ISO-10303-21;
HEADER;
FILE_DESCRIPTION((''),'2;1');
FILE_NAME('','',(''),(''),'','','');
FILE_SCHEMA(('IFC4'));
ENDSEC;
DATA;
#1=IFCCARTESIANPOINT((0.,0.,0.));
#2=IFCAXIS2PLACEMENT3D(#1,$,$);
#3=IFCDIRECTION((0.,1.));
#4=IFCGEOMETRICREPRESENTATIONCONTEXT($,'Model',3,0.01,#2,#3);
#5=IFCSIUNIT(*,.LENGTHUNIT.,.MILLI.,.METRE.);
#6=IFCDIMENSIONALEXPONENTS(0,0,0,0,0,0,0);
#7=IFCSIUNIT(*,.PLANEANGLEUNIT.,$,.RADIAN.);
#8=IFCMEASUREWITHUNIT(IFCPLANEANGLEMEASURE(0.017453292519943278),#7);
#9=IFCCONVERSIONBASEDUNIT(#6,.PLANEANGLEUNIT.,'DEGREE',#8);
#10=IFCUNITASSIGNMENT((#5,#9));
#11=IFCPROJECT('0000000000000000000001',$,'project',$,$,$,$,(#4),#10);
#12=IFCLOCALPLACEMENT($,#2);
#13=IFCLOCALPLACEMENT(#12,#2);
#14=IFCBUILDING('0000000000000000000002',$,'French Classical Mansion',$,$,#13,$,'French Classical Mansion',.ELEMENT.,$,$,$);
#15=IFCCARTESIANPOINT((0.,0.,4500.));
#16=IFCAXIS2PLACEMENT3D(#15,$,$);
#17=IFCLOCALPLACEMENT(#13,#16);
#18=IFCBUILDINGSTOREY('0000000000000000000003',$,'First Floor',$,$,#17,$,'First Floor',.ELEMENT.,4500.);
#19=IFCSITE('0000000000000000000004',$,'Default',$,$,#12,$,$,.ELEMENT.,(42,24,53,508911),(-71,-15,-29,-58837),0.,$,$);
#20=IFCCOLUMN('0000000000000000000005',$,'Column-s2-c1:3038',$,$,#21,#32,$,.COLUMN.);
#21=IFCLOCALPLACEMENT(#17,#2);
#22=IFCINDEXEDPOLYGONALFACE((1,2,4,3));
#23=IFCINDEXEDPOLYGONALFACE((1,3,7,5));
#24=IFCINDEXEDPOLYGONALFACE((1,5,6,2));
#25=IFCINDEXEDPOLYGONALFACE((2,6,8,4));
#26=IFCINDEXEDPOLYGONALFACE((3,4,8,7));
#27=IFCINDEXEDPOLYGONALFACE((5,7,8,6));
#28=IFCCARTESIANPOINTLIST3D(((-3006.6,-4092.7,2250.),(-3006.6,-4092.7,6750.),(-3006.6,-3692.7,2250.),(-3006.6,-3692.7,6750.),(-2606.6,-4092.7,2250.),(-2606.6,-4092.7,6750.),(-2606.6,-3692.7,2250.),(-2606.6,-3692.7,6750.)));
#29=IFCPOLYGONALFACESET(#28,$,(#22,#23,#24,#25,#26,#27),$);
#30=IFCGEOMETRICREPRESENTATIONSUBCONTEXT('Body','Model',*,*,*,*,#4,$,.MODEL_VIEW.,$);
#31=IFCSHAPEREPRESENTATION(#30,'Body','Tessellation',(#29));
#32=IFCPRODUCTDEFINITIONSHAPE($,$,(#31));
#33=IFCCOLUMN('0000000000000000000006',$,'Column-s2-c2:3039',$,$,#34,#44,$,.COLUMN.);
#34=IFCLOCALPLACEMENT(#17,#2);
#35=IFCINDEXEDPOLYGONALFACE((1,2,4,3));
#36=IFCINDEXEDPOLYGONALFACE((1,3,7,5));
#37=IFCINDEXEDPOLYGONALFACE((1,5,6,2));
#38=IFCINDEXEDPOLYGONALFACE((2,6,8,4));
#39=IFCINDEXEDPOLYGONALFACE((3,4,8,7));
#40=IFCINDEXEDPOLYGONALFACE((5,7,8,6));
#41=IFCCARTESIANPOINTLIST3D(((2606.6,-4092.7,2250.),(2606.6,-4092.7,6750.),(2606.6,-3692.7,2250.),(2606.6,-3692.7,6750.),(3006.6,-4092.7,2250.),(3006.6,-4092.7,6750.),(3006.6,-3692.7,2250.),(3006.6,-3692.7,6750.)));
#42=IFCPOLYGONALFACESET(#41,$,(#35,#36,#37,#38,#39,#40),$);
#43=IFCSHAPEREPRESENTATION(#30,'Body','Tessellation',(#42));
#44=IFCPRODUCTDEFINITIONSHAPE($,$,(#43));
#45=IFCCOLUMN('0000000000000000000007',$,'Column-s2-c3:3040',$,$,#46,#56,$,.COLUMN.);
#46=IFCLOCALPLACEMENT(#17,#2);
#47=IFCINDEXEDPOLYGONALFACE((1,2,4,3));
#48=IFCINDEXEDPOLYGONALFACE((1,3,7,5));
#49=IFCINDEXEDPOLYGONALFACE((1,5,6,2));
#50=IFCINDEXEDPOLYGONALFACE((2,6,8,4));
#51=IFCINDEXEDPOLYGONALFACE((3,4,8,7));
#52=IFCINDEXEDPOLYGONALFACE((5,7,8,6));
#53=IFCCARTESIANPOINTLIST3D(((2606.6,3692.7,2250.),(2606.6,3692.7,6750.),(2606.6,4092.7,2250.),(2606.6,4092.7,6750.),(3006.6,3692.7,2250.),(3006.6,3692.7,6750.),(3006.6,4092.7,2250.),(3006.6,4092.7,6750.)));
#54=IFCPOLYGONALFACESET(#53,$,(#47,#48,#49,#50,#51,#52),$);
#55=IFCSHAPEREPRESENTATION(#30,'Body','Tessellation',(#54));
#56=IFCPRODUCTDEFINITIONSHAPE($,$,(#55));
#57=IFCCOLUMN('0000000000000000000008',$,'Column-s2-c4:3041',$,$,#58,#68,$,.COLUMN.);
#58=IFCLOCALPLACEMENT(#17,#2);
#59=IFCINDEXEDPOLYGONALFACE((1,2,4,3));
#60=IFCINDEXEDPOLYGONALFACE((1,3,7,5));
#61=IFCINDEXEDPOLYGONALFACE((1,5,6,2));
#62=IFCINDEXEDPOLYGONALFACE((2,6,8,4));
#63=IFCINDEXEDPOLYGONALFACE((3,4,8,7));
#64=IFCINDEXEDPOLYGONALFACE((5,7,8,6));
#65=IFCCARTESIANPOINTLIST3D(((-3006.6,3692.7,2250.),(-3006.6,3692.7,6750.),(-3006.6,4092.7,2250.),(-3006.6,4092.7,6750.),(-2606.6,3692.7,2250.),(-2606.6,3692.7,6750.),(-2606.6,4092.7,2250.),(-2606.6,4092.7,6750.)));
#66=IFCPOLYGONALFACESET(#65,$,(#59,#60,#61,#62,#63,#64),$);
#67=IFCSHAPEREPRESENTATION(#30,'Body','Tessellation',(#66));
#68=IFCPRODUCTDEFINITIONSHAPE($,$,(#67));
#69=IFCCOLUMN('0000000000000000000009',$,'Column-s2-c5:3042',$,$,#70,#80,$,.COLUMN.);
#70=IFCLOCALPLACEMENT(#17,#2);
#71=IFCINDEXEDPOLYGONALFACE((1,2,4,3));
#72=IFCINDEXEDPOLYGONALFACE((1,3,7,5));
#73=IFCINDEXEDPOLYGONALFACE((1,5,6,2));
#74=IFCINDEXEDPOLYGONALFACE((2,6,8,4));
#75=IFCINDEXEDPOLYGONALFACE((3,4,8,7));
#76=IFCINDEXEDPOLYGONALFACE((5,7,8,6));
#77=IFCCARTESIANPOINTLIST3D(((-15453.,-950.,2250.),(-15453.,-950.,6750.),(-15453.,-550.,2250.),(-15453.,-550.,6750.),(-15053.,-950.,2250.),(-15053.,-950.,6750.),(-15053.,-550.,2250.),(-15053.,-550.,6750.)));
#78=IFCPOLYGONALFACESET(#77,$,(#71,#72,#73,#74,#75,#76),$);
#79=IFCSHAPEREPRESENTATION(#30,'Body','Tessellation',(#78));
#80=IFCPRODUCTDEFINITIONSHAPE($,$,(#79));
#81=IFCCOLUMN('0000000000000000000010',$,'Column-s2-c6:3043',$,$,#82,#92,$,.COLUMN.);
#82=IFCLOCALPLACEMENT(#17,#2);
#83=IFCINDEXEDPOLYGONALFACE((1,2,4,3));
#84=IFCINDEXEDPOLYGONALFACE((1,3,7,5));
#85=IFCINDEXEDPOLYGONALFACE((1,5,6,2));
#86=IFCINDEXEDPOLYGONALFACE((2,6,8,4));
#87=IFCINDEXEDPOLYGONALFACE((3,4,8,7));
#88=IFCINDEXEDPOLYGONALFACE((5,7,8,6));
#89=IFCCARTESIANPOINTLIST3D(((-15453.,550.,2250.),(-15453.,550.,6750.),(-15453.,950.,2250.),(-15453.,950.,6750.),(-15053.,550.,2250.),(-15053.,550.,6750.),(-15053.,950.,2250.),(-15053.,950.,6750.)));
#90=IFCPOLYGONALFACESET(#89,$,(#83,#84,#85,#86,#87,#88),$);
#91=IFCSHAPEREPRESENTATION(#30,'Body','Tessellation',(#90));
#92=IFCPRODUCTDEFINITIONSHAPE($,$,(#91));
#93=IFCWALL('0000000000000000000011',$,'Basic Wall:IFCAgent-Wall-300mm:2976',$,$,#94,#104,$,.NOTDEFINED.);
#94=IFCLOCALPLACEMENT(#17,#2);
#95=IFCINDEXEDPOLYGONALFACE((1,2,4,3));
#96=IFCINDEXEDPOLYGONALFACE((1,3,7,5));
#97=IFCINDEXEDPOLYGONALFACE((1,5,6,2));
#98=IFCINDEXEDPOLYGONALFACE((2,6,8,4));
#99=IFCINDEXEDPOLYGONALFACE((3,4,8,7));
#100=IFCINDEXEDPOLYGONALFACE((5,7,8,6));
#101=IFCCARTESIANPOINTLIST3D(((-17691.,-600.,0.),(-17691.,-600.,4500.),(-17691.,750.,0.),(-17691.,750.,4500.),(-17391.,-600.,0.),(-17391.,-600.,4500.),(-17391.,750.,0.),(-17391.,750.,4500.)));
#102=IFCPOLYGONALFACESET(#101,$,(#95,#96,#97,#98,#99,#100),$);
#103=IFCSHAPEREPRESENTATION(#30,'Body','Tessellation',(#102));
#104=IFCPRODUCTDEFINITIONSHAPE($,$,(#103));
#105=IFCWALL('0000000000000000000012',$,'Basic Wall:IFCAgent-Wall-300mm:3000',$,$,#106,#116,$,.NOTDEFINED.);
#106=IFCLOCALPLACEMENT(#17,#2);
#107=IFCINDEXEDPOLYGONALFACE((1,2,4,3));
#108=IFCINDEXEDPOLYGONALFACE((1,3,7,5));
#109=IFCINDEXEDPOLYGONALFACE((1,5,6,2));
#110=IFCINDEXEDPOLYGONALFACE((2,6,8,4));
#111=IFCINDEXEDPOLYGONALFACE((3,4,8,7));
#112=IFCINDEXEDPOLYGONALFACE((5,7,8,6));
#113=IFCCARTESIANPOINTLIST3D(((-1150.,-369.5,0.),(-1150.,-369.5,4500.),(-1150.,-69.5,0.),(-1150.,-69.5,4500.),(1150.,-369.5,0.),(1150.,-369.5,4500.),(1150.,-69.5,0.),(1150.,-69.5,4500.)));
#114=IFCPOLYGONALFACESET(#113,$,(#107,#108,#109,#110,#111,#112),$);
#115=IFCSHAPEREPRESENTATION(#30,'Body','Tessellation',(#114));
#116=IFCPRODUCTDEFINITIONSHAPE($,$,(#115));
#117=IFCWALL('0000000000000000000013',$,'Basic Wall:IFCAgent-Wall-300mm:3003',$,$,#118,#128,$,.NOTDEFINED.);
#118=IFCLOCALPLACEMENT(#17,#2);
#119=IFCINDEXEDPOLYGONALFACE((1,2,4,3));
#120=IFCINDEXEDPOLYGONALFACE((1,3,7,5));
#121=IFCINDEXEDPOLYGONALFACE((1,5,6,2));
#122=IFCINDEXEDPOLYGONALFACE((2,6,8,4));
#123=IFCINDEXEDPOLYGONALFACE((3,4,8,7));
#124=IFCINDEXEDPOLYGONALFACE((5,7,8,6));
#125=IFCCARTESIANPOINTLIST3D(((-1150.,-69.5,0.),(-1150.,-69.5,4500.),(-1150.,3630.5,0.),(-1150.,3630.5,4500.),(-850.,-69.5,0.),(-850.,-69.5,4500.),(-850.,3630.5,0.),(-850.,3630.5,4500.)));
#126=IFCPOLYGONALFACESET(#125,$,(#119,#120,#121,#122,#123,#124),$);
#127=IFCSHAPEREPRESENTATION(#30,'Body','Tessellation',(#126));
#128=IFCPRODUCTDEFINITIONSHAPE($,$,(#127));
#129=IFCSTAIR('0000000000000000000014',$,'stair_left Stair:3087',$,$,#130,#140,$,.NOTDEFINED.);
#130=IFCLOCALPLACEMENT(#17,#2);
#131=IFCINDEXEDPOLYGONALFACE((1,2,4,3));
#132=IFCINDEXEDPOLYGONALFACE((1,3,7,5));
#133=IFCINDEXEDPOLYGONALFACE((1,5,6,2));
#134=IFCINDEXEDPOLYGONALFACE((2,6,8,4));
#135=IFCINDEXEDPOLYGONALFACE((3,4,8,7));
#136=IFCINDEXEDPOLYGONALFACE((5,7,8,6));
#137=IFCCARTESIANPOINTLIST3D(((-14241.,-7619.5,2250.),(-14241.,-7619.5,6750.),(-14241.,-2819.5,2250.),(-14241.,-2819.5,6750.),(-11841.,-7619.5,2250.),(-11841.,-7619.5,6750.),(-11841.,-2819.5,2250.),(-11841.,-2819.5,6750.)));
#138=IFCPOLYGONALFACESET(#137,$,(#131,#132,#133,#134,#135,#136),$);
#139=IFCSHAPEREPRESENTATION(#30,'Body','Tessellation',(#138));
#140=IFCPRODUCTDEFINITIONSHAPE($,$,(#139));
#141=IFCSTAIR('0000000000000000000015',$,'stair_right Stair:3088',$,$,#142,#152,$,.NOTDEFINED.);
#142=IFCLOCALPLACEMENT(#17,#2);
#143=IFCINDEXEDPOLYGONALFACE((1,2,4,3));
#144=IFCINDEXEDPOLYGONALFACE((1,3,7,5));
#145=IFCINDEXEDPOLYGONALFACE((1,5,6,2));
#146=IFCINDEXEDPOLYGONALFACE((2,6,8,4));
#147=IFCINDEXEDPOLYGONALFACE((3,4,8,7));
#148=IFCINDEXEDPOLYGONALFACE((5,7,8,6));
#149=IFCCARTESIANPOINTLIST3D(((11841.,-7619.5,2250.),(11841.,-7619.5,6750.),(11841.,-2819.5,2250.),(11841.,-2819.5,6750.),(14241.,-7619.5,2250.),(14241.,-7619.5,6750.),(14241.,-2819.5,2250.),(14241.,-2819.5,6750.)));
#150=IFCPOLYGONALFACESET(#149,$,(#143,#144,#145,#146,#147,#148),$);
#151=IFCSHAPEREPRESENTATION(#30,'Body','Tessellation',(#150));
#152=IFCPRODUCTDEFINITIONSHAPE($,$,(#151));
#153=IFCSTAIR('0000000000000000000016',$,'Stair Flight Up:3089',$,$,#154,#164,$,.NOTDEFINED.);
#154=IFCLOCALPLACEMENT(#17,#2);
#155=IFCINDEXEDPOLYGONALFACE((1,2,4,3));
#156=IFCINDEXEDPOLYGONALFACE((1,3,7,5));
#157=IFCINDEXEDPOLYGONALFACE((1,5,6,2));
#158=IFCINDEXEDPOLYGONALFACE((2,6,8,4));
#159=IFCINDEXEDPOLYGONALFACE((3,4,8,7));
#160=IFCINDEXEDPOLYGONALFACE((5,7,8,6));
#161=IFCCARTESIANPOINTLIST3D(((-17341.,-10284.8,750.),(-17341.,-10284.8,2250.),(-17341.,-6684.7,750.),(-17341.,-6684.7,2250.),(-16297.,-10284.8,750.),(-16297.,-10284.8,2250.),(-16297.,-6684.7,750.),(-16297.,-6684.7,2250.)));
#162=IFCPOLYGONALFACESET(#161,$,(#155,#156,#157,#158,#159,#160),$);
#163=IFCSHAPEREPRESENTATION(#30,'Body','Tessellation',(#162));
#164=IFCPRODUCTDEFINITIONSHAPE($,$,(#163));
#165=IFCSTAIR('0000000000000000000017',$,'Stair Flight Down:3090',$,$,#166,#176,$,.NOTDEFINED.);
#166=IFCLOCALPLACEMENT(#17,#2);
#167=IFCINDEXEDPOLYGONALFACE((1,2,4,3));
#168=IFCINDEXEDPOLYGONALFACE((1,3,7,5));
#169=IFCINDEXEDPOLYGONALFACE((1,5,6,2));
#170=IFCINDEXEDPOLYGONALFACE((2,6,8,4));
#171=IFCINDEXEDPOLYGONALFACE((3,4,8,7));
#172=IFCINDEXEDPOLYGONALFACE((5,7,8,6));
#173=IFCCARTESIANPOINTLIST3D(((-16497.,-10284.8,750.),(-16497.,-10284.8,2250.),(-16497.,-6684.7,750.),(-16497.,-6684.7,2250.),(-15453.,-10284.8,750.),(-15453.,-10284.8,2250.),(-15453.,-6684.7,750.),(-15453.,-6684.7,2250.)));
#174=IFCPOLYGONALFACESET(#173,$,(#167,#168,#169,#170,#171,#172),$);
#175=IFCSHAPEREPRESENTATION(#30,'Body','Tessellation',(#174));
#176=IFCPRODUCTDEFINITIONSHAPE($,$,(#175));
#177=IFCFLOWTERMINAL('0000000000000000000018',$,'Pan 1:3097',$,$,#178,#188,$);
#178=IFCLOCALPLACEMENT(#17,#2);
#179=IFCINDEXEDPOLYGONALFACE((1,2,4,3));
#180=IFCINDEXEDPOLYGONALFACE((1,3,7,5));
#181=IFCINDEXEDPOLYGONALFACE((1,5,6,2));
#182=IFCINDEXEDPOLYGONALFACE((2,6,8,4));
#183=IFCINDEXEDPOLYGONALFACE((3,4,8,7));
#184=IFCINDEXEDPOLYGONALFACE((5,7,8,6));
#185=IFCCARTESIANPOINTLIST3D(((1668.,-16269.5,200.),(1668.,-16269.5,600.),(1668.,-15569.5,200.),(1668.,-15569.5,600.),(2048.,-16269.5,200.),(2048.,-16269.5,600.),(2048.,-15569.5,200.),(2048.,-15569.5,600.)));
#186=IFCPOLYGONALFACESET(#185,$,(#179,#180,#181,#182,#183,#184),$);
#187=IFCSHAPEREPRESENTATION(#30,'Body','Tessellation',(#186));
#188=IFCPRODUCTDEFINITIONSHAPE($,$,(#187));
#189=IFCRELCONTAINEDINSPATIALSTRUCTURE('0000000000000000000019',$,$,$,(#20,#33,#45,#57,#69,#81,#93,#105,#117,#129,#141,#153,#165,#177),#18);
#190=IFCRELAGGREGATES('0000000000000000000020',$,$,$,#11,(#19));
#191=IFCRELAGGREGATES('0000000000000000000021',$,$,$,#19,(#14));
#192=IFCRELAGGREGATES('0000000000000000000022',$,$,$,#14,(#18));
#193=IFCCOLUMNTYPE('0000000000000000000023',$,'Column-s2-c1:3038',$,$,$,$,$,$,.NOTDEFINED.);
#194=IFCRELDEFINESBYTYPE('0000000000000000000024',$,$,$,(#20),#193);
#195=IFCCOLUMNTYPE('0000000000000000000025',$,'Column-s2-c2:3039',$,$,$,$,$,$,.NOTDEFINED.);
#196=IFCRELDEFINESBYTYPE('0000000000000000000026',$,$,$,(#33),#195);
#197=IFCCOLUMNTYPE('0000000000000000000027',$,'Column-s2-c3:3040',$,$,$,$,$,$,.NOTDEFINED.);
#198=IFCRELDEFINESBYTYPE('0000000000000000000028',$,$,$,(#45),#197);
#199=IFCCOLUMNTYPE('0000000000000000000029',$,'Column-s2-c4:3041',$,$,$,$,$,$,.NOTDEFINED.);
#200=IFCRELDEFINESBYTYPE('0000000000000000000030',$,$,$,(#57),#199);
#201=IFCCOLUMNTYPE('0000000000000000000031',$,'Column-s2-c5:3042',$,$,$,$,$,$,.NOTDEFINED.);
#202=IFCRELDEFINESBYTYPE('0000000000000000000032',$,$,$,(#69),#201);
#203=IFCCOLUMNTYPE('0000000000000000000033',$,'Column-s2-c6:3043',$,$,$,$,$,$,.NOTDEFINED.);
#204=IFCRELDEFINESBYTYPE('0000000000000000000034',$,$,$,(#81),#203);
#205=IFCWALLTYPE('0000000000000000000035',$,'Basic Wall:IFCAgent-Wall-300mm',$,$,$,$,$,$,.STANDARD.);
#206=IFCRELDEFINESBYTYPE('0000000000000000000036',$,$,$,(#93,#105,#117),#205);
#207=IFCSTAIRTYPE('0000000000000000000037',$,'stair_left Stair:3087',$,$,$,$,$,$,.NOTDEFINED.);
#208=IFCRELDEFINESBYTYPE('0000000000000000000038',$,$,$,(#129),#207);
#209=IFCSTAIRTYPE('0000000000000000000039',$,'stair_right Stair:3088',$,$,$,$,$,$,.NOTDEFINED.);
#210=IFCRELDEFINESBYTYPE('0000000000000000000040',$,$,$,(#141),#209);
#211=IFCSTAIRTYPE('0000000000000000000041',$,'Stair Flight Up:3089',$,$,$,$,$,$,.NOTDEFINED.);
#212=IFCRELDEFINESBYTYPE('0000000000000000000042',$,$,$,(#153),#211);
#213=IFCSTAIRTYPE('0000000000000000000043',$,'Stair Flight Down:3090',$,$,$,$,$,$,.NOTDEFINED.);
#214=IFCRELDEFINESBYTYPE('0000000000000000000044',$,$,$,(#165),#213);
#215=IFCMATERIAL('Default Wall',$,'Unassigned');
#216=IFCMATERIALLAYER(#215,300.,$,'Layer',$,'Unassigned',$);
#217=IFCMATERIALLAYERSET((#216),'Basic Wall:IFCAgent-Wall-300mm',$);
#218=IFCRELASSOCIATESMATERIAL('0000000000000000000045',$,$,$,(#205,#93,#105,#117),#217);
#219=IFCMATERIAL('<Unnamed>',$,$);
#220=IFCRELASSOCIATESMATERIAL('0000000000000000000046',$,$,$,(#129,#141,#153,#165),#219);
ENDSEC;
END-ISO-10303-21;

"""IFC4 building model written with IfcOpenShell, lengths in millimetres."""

from ifc_helpers import new_model, entity, si_unit, converted_unit, direction, frame, frame_2d, origin, origin_2d_with_axis, place, context, subcontext, project, spatial, rectangle, extrude, material, layer, layer_set, layer_usage, type_object, element, save


model = new_model("IFC4")

# Units and contexts
model_context = context("Model", 3, precision=0.01, world=origin(), true_north=direction((0.0, 1.0)))
body_context = subcontext(model_context, "Body", "Model", "MODEL_VIEW")
ifc_project = project(units=[si_unit("LENGTHUNIT", "METRE", prefix="MILLI"), converted_unit("PLANEANGLEUNIT", "DEGREE", entity("IfcPlaneAngleMeasure", 0.017453292519943278), si_unit("PLANEANGLEUNIT", "RADIAN"), dimensions=[0, 0, 0, 0, 0, 0, 0])], contexts=[model_context])

# Site, building, storey
site_placement = place(None, origin())
site = spatial("IfcSite", under=ifc_project, at=site_placement, Name="Default", CompositionType="ELEMENT", RefLatitude=(42, 24, 53, 508911), RefLongitude=(-71, -15, -29, -58837), RefElevation=0.0)
building_placement = place(site_placement, origin())
building = spatial("IfcBuilding", under=site, at=building_placement, Name="French Classical Mansion", LongName="French Classical Mansion", CompositionType="ELEMENT")
storey_placement = place(building_placement, frame((0.0, 0.0, 4500.0)))
storey = spatial("IfcBuildingStorey", under=building, at=storey_placement, Name="First Floor", LongName="First Floor", CompositionType="ELEMENT", Elevation=4500.0)

# Columns
column_type_1 = type_object("IfcColumnType", Name="Column-s2-c1:3038", PredefinedType="NOTDEFINED")
column_1_placement = place(storey_placement, origin())
element("IfcColumn", 1, at=column_1_placement, inside=storey, type_object=column_type_1, Name="Column-s2-c1:3038", PredefinedType="COLUMN", context=body_context, shape_type="SweptSolid", body=[
    extrude(rectangle(XDim=400.0, YDim=400.0, at=origin_2d_with_axis()), frame((-2806.6, -3892.7, 2250.0)), (0.0, 0.0, 1.0), 4500.0),
])
column_type_2 = type_object("IfcColumnType", Name="Column-s2-c2:3039", PredefinedType="NOTDEFINED")
column_2_placement = place(storey_placement, origin())
element("IfcColumn", 2, at=column_2_placement, inside=storey, type_object=column_type_2, Name="Column-s2-c2:3039", PredefinedType="COLUMN", context=body_context, shape_type="SweptSolid", body=[
    extrude(rectangle(XDim=400.0, YDim=400.0, at=origin_2d_with_axis()), frame((2806.6, -3892.7, 2250.0)), (0.0, 0.0, 1.0), 4500.0),
])
column_type_3 = type_object("IfcColumnType", Name="Column-s2-c3:3040", PredefinedType="NOTDEFINED")
column_3_placement = place(storey_placement, origin())
element("IfcColumn", 3, at=column_3_placement, inside=storey, type_object=column_type_3, Name="Column-s2-c3:3040", PredefinedType="COLUMN", context=body_context, shape_type="SweptSolid", body=[
    extrude(rectangle(XDim=400.0, YDim=400.0, at=origin_2d_with_axis()), frame((2806.6, 3892.7, 2250.0)), (0.0, 0.0, 1.0), 4500.0),
])
column_type_4 = type_object("IfcColumnType", Name="Column-s2-c4:3041", PredefinedType="NOTDEFINED")
column_4_placement = place(storey_placement, origin())
element("IfcColumn", 4, at=column_4_placement, inside=storey, type_object=column_type_4, Name="Column-s2-c4:3041", PredefinedType="COLUMN", context=body_context, shape_type="SweptSolid", body=[
    extrude(rectangle(XDim=400.0, YDim=400.0, at=origin_2d_with_axis()), frame((-2806.6, 3892.7, 2250.0)), (0.0, 0.0, 1.0), 4500.0),
])
column_type_5 = type_object("IfcColumnType", Name="Column-s2-c5:3042", PredefinedType="NOTDEFINED")
column_5_placement = place(storey_placement, origin())
element("IfcColumn", 5, at=column_5_placement, inside=storey, type_object=column_type_5, Name="Column-s2-c5:3042", PredefinedType="COLUMN", context=body_context, shape_type="SweptSolid", body=[
    extrude(rectangle(XDim=400.0, YDim=400.0, at=origin_2d_with_axis()), frame((-15253.0, -750.0, 2250.0)), (0.0, 0.0, 1.0), 4500.0),
])
column_type_6 = type_object("IfcColumnType", Name="Column-s2-c6:3043", PredefinedType="NOTDEFINED")
column_6_placement = place(storey_placement, origin())
element("IfcColumn", 6, at=column_6_placement, inside=storey, type_object=column_type_6, Name="Column-s2-c6:3043", PredefinedType="COLUMN", context=body_context, shape_type="SweptSolid", body=[
    extrude(rectangle(XDim=400.0, YDim=400.0, at=origin_2d_with_axis()), frame((-15253.0, 750.0, 2250.0)), (0.0, 0.0, 1.0), 4500.0),
])

# Shared definitions
ifc_material_1 = material(Name="<Unnamed>")

# Walls
ifc_material_2 = material(Name="Default Wall", Category="Unassigned")
ifc_layer_1 = layer(ifc_material_2, 300.0, Name="Layer", Category="Unassigned")
ifc_layer_set_1 = layer_set([ifc_layer_1], Name="Basic Wall:IFCAgent-Wall-300mm")
ifc_layer_usage_1 = layer_usage(ifc_layer_set_1, "AXIS2", "NEGATIVE", 150.0)
wall_type = type_object("IfcWallType", Name="Basic Wall:IFCAgent-Wall-300mm", PredefinedType="STANDARD", material=ifc_layer_set_1)
wall_1_placement = place(storey_placement, frame((-17541.0, -600.0, 0.0), z_axis=(0.0, 0.0, 1.0), x_axis=(0.0, 1.0, 0.0)))
element("IfcWall", 7, at=wall_1_placement, inside=storey, type_object=wall_type, material=ifc_layer_usage_1, Name="Basic Wall:IFCAgent-Wall-300mm:2976", PredefinedType="NOTDEFINED", context=body_context, shape_type="SweptSolid", body=[
    extrude(rectangle(XDim=1350.0, YDim=300.0, at=frame_2d((675.0, 0.0), x_axis=(-1.0, 0.0))), origin(), (0.0, 0.0, 1.0), 4500.0),
])
ifc_layer_usage_2 = layer_usage(ifc_layer_set_1, "AXIS2", "NEGATIVE", 150.0)
wall_2_placement = place(storey_placement, frame((-1150.0, -219.5, 0.0)))
element("IfcWall", 8, at=wall_2_placement, inside=storey, type_object=wall_type, material=ifc_layer_usage_2, Name="Basic Wall:IFCAgent-Wall-300mm:3000", PredefinedType="NOTDEFINED", context=body_context, shape_type="SweptSolid", body=[
    extrude(rectangle(XDim=2300.0, YDim=300.0, at=frame_2d((1150.0, 0.0), x_axis=(-1.0, 0.0))), origin(), (0.0, 0.0, 1.0), 4500.0),
])
ifc_layer_usage_3 = layer_usage(ifc_layer_set_1, "AXIS2", "NEGATIVE", 150.0)
wall_3_placement = place(storey_placement, frame((-1000.0, 3630.5, 0.0), z_axis=(0.0, 0.0, 1.0), x_axis=(0.0, -1.0, 0.0)))
element("IfcWall", 9, at=wall_3_placement, inside=storey, type_object=wall_type, material=ifc_layer_usage_3, Name="Basic Wall:IFCAgent-Wall-300mm:3003", PredefinedType="NOTDEFINED", context=body_context, shape_type="SweptSolid", body=[
    extrude(rectangle(XDim=3700.0, YDim=300.0, at=frame_2d((1850.0, 0.0), x_axis=(-1.0, 0.0))), origin(), (0.0, 0.0, 1.0), 4500.0),
])

# Stairs
stair_type_1 = type_object("IfcStairType", Name="stair_left Stair:3087", PredefinedType="NOTDEFINED")
stair_1_placement = place(storey_placement, origin())
element("IfcStair", 10, at=stair_1_placement, inside=storey, type_object=stair_type_1, material=ifc_material_1, Name="stair_left Stair:3087", PredefinedType="NOTDEFINED", context=body_context, shape_type="SweptSolid", body=[
    extrude(rectangle(XDim=2400.0, YDim=4800.0, at=origin_2d_with_axis()), frame((-13041.0, -5219.5, 2250.0)), (0.0, 0.0, 1.0), 4500.0),
])
stair_type_2 = type_object("IfcStairType", Name="stair_right Stair:3088", PredefinedType="NOTDEFINED")
stair_2_placement = place(storey_placement, origin())
element("IfcStair", 11, at=stair_2_placement, inside=storey, type_object=stair_type_2, material=ifc_material_1, Name="stair_right Stair:3088", PredefinedType="NOTDEFINED", context=body_context, shape_type="SweptSolid", body=[
    extrude(rectangle(XDim=2400.0, YDim=4800.0, at=origin_2d_with_axis()), frame((13041.0, -5219.5, 2250.0)), (0.0, 0.0, 1.0), 4500.0),
])
stair_type_3 = type_object("IfcStairType", Name="Stair Flight Up:3089", PredefinedType="NOTDEFINED")
stair_3_placement = place(storey_placement, origin())
element("IfcStair", 12, at=stair_3_placement, inside=storey, type_object=stair_type_3, material=ifc_material_1, Name="Stair Flight Up:3089", PredefinedType="NOTDEFINED", context=body_context, shape_type="SweptSolid", body=[
    extrude(rectangle(XDim=1044.0, YDim=3600.0, at=frame_2d((0.0, 0.0), x_axis=(1.0, 0.0))), frame((-16819.0, -8484.8, 750.0)), (0.0, 0.0, 1.0), 1500.0),
])
stair_type_4 = type_object("IfcStairType", Name="Stair Flight Down:3090", PredefinedType="NOTDEFINED")
stair_4_placement = place(storey_placement, origin())
element("IfcStair", 13, at=stair_4_placement, inside=storey, type_object=stair_type_4, material=ifc_material_1, Name="Stair Flight Down:3090", PredefinedType="NOTDEFINED", context=body_context, shape_type="SweptSolid", body=[
    extrude(rectangle(XDim=1044.0, YDim=3600.0, at=frame_2d((0.0, 0.0), x_axis=(1.0, 0.0))), frame((-15975.0, -8484.8, 750.0)), (0.0, 0.0, 1.0), 1500.0),
])

# Flow terminal
flow_terminal_1_placement = place(storey_placement, origin())
element("IfcFlowTerminal", 14, at=flow_terminal_1_placement, inside=storey, Name="Pan 1:3097", context=body_context, shape_type="SweptSolid", body=[
    extrude(rectangle(XDim=700.0, YDim=380.0, at=origin_2d_with_axis()), frame((1858.0, -15919.5, 200.0), z_axis=(0.0, 0.0, 1.0), x_axis=(0.0, 1.0, 0.0)), (0.0, 0.0, 1.0), 400.0),
])

save(model, "model.ifc")
